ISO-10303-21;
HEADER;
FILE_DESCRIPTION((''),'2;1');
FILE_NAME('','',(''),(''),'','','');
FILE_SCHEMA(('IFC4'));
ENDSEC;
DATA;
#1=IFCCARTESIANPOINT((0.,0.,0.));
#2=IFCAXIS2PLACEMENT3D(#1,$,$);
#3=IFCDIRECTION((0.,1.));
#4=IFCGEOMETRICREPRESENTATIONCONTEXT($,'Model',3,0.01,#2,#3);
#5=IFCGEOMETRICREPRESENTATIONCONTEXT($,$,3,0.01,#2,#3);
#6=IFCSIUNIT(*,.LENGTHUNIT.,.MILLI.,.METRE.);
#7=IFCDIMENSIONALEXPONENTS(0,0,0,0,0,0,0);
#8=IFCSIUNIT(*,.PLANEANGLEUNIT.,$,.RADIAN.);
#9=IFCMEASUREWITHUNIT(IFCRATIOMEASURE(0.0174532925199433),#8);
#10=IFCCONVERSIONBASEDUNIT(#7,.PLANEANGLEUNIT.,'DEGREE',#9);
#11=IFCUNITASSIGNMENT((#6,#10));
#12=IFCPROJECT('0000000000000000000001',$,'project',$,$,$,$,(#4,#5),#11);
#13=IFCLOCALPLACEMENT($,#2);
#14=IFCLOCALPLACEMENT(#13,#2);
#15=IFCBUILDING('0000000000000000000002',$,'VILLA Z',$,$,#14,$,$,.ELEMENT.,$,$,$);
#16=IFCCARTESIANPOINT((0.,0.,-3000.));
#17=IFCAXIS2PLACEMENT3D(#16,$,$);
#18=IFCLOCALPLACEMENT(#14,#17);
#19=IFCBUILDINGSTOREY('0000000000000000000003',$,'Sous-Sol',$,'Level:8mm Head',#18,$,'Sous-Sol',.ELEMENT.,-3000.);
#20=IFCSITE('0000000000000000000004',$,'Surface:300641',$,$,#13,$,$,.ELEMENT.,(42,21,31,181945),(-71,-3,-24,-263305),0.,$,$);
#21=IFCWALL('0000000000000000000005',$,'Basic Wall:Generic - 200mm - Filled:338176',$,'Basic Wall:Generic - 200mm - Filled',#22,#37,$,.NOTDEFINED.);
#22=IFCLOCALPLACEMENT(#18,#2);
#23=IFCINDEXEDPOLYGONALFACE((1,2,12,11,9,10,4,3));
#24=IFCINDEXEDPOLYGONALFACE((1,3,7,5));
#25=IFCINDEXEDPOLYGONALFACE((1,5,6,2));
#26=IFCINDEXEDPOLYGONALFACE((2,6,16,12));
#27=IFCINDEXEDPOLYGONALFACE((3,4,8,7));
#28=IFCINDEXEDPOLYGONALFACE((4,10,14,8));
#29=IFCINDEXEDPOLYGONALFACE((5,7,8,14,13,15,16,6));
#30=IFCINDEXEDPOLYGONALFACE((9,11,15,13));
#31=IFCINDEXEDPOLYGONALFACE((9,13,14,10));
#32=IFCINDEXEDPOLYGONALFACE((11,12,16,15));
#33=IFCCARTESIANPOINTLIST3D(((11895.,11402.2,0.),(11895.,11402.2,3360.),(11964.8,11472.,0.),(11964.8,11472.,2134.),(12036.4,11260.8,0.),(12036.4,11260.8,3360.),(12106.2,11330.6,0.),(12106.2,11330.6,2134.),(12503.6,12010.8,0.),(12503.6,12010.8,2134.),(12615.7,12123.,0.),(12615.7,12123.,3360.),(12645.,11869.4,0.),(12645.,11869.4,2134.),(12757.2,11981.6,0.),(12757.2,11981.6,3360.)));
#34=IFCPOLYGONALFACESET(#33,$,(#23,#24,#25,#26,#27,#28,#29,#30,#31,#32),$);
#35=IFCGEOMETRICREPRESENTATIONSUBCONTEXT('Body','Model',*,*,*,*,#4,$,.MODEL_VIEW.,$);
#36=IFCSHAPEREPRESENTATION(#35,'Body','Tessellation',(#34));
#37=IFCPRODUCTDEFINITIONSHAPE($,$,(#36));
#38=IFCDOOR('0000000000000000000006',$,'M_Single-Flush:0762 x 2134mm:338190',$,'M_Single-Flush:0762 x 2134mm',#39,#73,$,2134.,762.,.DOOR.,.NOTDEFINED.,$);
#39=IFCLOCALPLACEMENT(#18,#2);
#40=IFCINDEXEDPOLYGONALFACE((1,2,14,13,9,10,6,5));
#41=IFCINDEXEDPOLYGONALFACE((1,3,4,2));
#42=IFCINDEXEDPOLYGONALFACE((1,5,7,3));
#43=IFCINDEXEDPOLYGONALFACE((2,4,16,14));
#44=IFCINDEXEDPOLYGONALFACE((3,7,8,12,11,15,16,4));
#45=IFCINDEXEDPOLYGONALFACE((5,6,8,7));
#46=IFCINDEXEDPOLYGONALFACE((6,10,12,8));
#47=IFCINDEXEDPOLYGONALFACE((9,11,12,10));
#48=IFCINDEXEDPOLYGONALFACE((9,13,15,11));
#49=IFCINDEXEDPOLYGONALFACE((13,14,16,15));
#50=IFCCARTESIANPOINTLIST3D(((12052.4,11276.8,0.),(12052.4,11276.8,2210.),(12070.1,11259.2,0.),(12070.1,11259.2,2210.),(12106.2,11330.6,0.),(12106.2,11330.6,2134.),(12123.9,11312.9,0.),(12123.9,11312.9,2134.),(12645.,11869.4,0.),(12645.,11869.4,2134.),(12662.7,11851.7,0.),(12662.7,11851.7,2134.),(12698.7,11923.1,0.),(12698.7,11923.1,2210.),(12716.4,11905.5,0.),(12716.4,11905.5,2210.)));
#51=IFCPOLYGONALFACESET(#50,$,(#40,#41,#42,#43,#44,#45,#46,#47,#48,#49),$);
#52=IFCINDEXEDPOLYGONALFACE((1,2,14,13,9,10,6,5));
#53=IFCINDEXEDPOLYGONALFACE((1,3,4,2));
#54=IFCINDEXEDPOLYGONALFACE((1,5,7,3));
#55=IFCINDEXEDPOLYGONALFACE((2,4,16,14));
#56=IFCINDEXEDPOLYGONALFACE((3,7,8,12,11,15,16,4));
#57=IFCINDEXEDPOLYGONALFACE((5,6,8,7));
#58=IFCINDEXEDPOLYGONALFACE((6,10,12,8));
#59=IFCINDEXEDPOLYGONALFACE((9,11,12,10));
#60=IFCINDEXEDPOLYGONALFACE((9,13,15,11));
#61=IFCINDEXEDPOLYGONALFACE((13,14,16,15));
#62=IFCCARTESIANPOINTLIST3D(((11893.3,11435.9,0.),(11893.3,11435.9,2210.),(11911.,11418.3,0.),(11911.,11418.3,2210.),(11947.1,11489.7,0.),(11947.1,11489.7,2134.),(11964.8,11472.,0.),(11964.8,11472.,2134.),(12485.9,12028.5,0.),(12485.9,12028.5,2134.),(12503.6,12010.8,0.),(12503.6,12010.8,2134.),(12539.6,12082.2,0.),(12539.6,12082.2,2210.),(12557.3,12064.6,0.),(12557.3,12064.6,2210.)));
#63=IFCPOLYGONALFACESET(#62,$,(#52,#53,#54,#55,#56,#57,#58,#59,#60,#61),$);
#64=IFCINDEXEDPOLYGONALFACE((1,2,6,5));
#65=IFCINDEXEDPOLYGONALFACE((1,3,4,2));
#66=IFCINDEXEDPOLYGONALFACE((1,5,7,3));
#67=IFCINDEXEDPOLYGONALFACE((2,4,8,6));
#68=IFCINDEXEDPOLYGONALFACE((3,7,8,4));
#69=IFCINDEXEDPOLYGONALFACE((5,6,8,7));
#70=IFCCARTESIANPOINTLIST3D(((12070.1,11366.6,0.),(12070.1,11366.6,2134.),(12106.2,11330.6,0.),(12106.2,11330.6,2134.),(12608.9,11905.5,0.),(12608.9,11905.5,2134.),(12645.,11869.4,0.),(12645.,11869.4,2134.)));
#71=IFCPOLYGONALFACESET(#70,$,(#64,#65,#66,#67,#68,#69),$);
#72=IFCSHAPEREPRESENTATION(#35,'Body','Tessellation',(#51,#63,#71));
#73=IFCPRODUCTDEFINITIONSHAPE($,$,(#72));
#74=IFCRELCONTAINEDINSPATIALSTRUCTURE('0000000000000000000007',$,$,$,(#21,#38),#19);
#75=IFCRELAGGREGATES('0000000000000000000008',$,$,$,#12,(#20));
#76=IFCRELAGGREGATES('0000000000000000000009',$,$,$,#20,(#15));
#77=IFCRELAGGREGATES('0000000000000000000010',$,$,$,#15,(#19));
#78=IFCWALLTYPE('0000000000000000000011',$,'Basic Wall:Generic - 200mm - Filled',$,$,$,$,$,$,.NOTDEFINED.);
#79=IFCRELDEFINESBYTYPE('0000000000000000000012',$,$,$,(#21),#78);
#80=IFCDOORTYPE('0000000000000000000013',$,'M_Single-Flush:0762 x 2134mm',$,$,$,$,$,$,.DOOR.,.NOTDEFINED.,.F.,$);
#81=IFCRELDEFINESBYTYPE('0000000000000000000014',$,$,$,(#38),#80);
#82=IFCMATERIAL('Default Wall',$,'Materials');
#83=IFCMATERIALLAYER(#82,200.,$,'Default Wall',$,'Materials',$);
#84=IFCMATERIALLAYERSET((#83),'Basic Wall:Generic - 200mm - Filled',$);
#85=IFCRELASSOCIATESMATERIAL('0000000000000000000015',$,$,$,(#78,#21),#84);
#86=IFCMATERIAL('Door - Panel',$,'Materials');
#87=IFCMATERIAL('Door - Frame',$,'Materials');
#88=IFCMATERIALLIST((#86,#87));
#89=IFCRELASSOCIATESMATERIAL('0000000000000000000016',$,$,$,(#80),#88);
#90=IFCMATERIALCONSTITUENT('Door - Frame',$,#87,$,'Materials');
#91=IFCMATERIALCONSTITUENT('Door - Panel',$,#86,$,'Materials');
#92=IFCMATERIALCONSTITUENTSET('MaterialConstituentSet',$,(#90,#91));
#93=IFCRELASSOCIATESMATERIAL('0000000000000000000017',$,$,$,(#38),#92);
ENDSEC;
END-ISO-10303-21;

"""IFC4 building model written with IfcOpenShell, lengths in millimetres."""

from ifc_helpers import new_model, entity, si_unit, converted_unit, direction, frame, frame_2d, origin, place, context, subcontext, project, spatial, polyline, rectangle, outline, extrude, clip, bounded_halfspace, source, transform, mapped, material, material_list, layer, layer_set, layer_usage, constituent, constituent_set, type_object, type_shapes, element, fill, save


model = new_model("IFC4")

# Units and contexts
model_context = context("Model", 3, precision=0.01, world=origin(), true_north=direction((0.0, 1.0)))
context_of_model = context(None, 3, precision=0.01, world=origin(), true_north=direction((0.0, 1.0)))
body_context = subcontext(model_context, "Body", "Model", "MODEL_VIEW")
ifc_project = project(units=[si_unit("LENGTHUNIT", "METRE", prefix="MILLI"), converted_unit("PLANEANGLEUNIT", "DEGREE", entity("IfcRatioMeasure", 0.0174532925199433), si_unit("PLANEANGLEUNIT", "RADIAN"), dimensions=[0, 0, 0, 0, 0, 0, 0])], contexts=[model_context, context_of_model])

# Site, building, storey
site_placement = place(None, origin())
site = spatial("IfcSite", under=ifc_project, at=site_placement, Name="Surface:300641", CompositionType="ELEMENT", RefLatitude=(42, 21, 31, 181945), RefLongitude=(-71, -3, -24, -263305), RefElevation=0.0)
building_placement = place(site_placement, origin())
building = spatial("IfcBuilding", under=site, at=building_placement, Name="VILLA Z", CompositionType="ELEMENT")
storey_placement = place(building_placement, frame((0.0, 0.0, -3000.0)))
storey = spatial("IfcBuildingStorey", under=building, at=storey_placement, Name="Sous-Sol", ObjectType="Level:8mm Head", LongName="Sous-Sol", CompositionType="ELEMENT", Elevation=-3000.0)

# Shared definitions
ifc_material_1 = material(Name="Default Wall", Category="Materials")

# Shared definitions
ifc_layer_1 = layer(ifc_material_1, 200.0, Name="Default Wall", Category="Materials")
ifc_layer_set_1 = layer_set([ifc_layer_1], Name="Basic Wall:Generic - 200mm - Filled")
wall_type_1 = type_object("IfcWallType", Name="Basic Wall:Generic - 200mm - Filled", PredefinedType="NOTDEFINED", material=ifc_layer_set_1)

# Wall, opening, door
ifc_layer_usage_1 = layer_usage(ifc_layer_set_1, "AXIS2", "NEGATIVE", 100.0)
wall_1_placement = place(storey_placement, frame((11965.7, 11331.5, 0.0), z_axis=(0.0, 0.0, 1.0), x_axis=(0.707107, 0.707107, 0.0)))
wall_1 = element("IfcWall", 1, at=wall_1_placement, inside=storey, type_object=wall_type_1, material=ifc_layer_usage_1, Name="Basic Wall:Generic - 200mm - Filled:338176", ObjectType="Basic Wall:Generic - 200mm - Filled", PredefinedType="NOTDEFINED", context=body_context, shape_type="Clipping", body=[
    clip(extrude(rectangle(XDim=1019.3, YDim=200.0, at=frame_2d((509.6, 0.0), x_axis=(-1.0, 0.0))), origin(), (0.0, 0.0, 1.0), 3360.0), bounded_halfspace(frame((0.0, -100.0, 3360.0), z_axis=(0.0, 0.0, -1.0), x_axis=(-0.707107, -0.707107, 0.0)), True, frame((0.0, -100.0, 3360.0)), polyline([(0.0, 0.0), (1019.3, 0.0), (1019.3, 200.0), (0.0, 200.0), (0.0, 0.0)]))),
])
opening_1_placement = place(wall_1_placement, frame((860.6, 100.0, 0.0)))
opening_1 = element("IfcOpeningElement", 2, at=opening_1_placement, cuts=wall_1, ObjectType="Opening", PredefinedType="OPENING", context=body_context, shape_type="SweptSolid", body=[
    extrude(rectangle(XDim=762.0, YDim=2134.0, at=frame_2d((1067.0, 381.0), x_axis=(0.0, 1.0))), frame((0.0, 0.0, 0.0), z_axis=(0.0, -1.0, 0.0), x_axis=(0.0, 0.0, 1.0)), (0.0, 0.0, 1.0), 200.0),
])
ifc_material_2 = material(Name="Door - Frame", Category="Materials")
ifc_constituent_1 = constituent(ifc_material_2, Name="Door - Frame", Category="Materials")
ifc_material_3 = material(Name="Door - Panel", Category="Materials")
ifc_constituent_2 = constituent(ifc_material_3, Name="Door - Panel", Category="Materials")
ifc_constituent_set_1 = constituent_set(constituents=[ifc_constituent_1, ifc_constituent_2], Name="MaterialConstituentSet")
ifc_material_list_1 = material_list([ifc_material_3, ifc_material_2])
door_type = type_object("IfcDoorType", Name="M_Single-Flush:0762 x 2134mm", OperationType="NOTDEFINED", ParameterTakesPrecedence=False, PredefinedType="DOOR", material=ifc_material_list_1)
shared_shape_1 = source(origin(), body_context, "Body", "SweptSolid", [
    extrude(outline(polyline([(-457.0, -1124.0), (457.0, -1124.0), (457.0, 1086.0), (381.0, 1086.0), (381.0, -1048.0), (-381.0, -1048.0), (-381.0, 1086.0), (-457.0, 1086.0), (-457.0, -1124.0)])), frame((381.0, 200.0, 1086.0), z_axis=(0.0, 1.0, 0.0), x_axis=(1.0, 0.0, 0.0)), (0.0, 0.0, 1.0), 25.0),
    extrude(outline(polyline([(-1124.0, -457.0), (1086.0, -457.0), (1086.0, -381.0), (-1048.0, -381.0), (-1048.0, 381.0), (1086.0, 381.0), (1086.0, 457.0), (-1124.0, 457.0), (-1124.0, -457.0)])), frame((381.0, -25.0, 1086.0), z_axis=(0.0, 1.0, 0.0), x_axis=(0.0, 0.0, -1.0)), (0.0, 0.0, 1.0), 25.0),
    extrude(rectangle(XDim=51.0, YDim=762.0, at=frame_2d((0.0, 0.0), x_axis=(1.0, 0.0))), frame((381.0, 174.5, 0.0), z_axis=(0.0, 0.0, 1.0), x_axis=(0.0, 1.0, 0.0)), (0.0, 0.0, 1.0), 2134.0),
])
type_shapes(door_type, [shared_shape_1])
door_placement = place(opening_1_placement, frame((0.0, 0.0, 0.0), z_axis=(0.0, 0.0, 1.0), x_axis=(-1.0, 0.0, 0.0)))
door = element("IfcDoor", 3, at=door_placement, inside=storey, type_object=door_type, material=ifc_constituent_set_1, Name="M_Single-Flush:0762 x 2134mm:338190", ObjectType="M_Single-Flush:0762 x 2134mm", OperationType="NOTDEFINED", OverallHeight=2134.0, OverallWidth=762.0, PredefinedType="DOOR", context=body_context, shape_type="MappedRepresentation", body=[
    mapped(shared_shape_1, transform((0.0, 0.0, 0.0), scale=1.0)),
])
fill(opening_1, door)

save(model, "model.ifc")
